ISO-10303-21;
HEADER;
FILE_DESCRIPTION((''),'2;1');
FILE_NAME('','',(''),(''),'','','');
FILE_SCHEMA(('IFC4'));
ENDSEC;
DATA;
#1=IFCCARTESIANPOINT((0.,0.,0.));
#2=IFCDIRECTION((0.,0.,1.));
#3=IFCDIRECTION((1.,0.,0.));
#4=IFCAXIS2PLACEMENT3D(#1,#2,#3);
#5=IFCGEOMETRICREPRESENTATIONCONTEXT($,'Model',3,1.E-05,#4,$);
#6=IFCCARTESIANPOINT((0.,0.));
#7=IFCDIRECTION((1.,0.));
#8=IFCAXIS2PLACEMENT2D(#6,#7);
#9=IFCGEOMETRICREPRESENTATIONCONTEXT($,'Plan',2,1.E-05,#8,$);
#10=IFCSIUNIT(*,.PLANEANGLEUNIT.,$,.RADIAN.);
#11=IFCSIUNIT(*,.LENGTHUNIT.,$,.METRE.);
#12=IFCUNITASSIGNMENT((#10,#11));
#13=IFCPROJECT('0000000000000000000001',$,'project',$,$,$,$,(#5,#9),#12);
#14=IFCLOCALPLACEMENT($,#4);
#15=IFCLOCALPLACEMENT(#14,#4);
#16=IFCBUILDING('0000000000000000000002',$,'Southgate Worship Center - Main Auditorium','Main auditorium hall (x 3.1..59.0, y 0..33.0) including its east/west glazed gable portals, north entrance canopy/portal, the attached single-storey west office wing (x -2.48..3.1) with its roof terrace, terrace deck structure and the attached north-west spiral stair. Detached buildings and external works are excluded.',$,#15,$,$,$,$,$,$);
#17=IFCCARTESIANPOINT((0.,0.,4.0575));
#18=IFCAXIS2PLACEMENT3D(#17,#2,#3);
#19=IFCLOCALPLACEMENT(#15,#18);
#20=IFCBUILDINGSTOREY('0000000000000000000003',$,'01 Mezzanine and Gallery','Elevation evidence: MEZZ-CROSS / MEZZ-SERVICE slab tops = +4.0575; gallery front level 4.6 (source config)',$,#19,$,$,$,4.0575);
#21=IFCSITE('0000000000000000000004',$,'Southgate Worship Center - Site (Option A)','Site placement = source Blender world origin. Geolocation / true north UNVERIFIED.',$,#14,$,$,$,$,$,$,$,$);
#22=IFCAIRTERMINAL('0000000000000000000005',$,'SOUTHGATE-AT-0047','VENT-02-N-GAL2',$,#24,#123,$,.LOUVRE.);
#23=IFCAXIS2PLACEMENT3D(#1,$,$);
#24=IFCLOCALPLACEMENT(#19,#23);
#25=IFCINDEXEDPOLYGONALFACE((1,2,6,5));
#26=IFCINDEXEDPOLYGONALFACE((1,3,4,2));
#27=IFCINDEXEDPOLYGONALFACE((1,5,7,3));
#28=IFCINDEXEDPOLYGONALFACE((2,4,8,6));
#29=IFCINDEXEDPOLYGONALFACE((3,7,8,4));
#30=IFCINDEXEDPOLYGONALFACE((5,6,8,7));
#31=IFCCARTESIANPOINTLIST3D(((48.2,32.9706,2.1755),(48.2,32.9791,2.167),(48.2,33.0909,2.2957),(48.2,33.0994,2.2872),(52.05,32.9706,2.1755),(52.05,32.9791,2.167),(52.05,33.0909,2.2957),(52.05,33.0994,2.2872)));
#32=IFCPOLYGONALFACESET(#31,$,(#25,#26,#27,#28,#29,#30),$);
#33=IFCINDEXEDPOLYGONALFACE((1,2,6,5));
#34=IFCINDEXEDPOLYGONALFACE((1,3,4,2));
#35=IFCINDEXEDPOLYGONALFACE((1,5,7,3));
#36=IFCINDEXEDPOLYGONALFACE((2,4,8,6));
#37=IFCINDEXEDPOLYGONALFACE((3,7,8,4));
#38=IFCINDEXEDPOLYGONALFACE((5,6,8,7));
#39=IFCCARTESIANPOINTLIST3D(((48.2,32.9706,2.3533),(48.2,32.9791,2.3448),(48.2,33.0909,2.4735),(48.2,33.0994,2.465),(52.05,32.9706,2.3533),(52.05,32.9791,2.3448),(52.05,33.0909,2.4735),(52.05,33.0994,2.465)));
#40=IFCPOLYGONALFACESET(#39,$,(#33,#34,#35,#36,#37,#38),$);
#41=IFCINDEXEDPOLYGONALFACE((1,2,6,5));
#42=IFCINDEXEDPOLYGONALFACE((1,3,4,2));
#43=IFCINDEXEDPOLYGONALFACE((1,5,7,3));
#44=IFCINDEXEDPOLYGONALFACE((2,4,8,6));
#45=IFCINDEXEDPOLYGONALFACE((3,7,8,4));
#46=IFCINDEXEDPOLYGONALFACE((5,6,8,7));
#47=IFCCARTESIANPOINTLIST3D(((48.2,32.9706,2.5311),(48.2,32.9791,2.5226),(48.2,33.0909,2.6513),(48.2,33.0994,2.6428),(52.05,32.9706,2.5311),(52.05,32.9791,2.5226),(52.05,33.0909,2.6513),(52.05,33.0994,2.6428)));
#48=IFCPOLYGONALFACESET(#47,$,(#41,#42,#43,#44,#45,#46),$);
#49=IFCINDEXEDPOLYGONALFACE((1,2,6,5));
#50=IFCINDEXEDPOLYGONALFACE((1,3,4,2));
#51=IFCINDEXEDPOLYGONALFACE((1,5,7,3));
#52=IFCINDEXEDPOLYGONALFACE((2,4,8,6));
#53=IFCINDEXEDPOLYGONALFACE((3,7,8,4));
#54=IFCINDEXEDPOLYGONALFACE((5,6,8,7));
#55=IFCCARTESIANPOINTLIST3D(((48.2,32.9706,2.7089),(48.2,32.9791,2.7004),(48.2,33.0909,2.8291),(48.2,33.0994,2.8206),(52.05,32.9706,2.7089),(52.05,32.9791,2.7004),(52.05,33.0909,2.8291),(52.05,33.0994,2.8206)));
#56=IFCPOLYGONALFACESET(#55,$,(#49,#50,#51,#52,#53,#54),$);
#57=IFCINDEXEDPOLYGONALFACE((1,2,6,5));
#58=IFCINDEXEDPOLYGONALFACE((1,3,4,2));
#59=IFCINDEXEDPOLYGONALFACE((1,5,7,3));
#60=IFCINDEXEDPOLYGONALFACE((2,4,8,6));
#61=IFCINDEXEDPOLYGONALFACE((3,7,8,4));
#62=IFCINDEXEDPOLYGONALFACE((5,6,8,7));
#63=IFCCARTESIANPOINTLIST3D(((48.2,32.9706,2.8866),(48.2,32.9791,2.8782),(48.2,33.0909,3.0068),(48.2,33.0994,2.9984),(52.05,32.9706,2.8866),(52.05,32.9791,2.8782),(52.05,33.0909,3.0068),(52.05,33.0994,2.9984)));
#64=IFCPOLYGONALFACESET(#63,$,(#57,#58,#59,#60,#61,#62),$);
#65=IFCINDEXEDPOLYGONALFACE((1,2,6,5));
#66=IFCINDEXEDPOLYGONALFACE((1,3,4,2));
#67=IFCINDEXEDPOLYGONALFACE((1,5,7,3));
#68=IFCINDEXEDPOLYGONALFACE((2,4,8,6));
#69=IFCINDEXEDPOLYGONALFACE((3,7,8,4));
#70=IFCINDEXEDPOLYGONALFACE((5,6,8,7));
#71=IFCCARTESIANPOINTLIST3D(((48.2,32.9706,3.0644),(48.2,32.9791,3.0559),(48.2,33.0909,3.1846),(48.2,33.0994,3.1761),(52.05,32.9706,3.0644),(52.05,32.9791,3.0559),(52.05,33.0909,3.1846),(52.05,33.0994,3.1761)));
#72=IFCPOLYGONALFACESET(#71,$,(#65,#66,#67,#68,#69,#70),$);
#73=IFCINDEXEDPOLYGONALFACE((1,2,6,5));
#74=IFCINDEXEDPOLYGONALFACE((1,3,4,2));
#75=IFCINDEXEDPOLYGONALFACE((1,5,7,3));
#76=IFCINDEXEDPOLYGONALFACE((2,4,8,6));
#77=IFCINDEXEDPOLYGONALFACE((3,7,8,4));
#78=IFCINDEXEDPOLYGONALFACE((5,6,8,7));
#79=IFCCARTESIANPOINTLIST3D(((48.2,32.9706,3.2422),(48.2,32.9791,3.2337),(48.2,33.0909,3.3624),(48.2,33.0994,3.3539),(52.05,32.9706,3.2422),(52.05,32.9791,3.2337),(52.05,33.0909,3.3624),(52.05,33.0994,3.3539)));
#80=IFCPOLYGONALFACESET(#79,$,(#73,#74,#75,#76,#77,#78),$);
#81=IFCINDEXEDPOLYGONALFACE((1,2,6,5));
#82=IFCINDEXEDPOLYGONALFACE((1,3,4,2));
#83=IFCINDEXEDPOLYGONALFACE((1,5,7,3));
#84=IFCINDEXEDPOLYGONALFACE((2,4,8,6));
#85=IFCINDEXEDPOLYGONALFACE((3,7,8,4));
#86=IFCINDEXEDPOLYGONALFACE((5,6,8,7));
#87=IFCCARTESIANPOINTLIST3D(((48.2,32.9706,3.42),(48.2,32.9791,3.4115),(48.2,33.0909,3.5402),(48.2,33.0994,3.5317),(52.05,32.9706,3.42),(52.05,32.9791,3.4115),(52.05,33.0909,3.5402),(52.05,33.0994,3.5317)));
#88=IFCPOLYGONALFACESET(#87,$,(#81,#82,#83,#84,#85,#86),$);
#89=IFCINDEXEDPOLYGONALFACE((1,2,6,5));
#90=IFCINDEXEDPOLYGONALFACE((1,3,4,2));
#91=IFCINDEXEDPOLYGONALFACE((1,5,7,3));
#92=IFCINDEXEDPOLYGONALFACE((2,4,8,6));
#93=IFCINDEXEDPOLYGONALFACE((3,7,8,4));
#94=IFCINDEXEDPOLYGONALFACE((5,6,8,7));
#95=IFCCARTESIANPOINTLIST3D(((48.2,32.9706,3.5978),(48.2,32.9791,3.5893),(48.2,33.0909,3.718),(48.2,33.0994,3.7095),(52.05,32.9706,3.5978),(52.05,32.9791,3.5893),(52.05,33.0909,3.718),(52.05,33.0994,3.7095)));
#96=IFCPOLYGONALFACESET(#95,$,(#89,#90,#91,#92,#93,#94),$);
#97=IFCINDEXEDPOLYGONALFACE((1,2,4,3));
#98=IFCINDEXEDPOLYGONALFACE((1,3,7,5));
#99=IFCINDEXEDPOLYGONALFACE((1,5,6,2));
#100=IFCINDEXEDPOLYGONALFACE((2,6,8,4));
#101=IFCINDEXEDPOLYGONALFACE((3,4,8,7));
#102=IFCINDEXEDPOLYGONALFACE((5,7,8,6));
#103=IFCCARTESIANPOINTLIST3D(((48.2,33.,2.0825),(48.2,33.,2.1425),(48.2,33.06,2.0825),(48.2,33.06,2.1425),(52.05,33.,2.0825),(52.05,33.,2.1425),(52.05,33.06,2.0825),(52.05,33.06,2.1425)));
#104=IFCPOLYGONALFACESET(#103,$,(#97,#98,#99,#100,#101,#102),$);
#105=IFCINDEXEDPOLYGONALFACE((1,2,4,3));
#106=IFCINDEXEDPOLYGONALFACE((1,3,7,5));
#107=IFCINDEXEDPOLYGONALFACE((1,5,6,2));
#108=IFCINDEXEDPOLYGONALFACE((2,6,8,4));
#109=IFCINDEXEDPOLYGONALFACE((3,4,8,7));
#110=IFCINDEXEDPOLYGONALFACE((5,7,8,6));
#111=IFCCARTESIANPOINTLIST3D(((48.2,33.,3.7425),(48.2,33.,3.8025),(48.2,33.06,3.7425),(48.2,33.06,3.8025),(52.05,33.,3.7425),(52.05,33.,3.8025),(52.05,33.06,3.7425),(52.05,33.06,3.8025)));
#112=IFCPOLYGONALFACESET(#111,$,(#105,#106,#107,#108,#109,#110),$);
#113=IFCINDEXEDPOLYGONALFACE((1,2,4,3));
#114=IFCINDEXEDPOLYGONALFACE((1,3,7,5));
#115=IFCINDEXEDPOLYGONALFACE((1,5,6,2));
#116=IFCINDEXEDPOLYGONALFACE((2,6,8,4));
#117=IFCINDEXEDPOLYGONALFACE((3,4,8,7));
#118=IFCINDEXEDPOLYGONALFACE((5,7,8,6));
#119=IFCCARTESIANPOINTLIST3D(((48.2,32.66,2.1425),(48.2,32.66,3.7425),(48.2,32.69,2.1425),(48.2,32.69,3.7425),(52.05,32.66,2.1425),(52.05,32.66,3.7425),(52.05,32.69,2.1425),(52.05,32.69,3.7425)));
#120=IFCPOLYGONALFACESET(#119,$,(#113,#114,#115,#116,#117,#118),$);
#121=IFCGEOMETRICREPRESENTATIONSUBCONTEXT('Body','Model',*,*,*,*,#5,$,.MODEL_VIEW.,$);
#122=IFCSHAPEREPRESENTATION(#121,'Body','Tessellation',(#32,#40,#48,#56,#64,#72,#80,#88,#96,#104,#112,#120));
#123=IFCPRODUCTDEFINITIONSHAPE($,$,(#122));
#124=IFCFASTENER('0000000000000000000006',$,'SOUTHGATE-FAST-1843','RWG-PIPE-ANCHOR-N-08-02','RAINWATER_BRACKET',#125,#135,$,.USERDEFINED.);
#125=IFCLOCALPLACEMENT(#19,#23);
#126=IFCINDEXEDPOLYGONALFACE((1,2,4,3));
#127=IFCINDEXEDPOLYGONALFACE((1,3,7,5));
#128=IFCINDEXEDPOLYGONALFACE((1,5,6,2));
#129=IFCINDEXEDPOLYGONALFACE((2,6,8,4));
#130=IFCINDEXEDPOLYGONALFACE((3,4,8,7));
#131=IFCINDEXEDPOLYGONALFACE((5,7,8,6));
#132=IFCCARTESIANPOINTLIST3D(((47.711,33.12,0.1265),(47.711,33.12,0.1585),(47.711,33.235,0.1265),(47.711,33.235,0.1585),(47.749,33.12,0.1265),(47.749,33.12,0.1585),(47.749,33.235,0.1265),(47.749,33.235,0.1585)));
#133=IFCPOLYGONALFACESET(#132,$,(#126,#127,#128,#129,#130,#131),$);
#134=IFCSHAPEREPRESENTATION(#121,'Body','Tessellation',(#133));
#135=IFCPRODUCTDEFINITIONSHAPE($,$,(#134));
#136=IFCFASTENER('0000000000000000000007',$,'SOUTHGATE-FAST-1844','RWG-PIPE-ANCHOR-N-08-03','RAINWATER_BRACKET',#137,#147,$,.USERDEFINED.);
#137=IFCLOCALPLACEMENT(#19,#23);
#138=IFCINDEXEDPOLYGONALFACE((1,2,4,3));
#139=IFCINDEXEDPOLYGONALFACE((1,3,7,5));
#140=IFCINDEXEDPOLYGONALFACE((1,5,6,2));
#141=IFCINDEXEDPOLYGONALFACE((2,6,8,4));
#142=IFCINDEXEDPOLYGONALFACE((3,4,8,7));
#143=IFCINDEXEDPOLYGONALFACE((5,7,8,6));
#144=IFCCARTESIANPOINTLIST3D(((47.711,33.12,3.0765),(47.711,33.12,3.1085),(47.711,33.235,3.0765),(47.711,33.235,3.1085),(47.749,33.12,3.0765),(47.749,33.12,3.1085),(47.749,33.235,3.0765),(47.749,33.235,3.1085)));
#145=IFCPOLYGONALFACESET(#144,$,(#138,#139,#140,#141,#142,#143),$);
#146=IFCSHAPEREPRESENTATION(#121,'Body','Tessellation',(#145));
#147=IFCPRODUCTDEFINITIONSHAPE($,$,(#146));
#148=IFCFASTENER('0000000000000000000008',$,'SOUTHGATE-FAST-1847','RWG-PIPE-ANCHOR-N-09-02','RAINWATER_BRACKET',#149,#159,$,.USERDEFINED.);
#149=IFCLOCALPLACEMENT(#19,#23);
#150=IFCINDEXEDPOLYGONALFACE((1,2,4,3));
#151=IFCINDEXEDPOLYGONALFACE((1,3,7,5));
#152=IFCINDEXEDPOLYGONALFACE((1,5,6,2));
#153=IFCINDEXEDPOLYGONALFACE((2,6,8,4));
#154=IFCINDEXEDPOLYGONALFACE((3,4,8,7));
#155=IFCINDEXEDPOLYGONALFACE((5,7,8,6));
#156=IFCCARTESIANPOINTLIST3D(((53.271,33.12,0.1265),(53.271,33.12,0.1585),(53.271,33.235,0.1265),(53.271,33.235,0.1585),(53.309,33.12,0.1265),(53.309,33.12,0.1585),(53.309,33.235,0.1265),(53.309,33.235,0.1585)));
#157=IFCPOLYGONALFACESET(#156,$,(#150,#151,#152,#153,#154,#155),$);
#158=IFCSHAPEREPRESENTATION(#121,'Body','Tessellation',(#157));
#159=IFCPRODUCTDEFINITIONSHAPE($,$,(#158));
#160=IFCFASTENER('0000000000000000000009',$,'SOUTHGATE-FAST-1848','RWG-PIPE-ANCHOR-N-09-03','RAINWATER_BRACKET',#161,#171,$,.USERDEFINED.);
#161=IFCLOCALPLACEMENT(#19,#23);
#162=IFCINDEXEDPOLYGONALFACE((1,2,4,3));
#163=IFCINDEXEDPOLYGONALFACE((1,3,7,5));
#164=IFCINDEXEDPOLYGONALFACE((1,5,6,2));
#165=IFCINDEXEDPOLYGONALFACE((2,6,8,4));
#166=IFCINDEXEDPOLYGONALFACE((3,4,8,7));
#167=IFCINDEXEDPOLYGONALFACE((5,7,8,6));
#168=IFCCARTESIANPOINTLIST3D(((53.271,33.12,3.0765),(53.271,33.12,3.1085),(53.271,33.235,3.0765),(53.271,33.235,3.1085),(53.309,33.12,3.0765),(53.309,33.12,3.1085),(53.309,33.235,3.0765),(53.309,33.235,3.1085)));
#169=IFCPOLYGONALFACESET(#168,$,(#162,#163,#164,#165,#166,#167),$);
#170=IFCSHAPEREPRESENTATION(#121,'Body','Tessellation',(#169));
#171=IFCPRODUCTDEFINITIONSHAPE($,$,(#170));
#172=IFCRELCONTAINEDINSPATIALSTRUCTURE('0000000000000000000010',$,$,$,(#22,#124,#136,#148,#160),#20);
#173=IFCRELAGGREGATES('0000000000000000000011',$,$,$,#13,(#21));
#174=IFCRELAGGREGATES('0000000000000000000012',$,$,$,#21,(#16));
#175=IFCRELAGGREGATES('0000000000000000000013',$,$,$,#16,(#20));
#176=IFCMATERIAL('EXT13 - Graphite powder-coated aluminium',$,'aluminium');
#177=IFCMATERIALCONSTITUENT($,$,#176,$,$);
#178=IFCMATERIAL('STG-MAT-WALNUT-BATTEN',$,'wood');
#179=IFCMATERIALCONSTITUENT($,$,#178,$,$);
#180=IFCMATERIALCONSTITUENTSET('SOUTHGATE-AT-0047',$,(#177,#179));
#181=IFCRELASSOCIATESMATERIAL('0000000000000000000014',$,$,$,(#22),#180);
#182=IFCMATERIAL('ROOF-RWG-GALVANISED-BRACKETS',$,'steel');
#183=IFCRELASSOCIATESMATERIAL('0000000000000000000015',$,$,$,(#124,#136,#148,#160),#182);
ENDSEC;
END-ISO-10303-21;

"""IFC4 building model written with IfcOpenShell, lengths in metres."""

from ifc_helpers import new_model, si_unit, frame, origin_with_axes, origin_2d, origin_2d_with_axis, place, context, subcontext, project, spatial, rectangle, extrude, material, constituent, constituent_set, element, save


model = new_model("IFC4")

# Units and contexts
model_context = context("Model", 3, precision=1e-05, world=origin_with_axes())
plan_context = context("Plan", 2, precision=1e-05, world=origin_2d_with_axis())
body_context = subcontext(model_context, "Body", "Model", "MODEL_VIEW")
ifc_project = project(units=[si_unit("PLANEANGLEUNIT", "RADIAN"), si_unit("LENGTHUNIT", "METRE")], contexts=[model_context, plan_context])

# Site, building, storey
site_placement = place(None, origin_with_axes())
site = spatial("IfcSite", under=ifc_project, at=site_placement, Name="Southgate Worship Center - Site (Option A)", Description="Site placement = source Blender world origin. Geolocation / true north UNVERIFIED.")
building_placement = place(site_placement, origin_with_axes())
building = spatial("IfcBuilding", under=site, at=building_placement, Name="Southgate Worship Center - Main Auditorium", Description="Main auditorium hall (x 3.1..59.0, y 0..33.0) including its east/west glazed gable portals, north entrance canopy/portal, the attached single-storey west office wing (x -2.48..3.1) with its roof terrace, terrace deck structure and the attached north-west spiral stair. Detached buildings and external works are excluded.")
storey_placement = place(building_placement, frame((0.0, 0.0, 4.0575), z_axis=(0.0, 0.0, 1.0), x_axis=(1.0, 0.0, 0.0)))
storey = spatial("IfcBuildingStorey", under=building, at=storey_placement, Name="01 Mezzanine and Gallery", Description="Elevation evidence: MEZZ-CROSS / MEZZ-SERVICE slab tops = +4.0575; gallery front level 4.6 (source config)", Elevation=4.0575)

# Air terminal
ifc_material_1 = material(Name="EXT13 - Graphite powder-coated aluminium", Category="aluminium")
ifc_constituent_1 = constituent(ifc_material_1)
ifc_material_2 = material(Name="STG-MAT-WALNUT-BATTEN", Category="wood")
ifc_constituent_2 = constituent(ifc_material_2)
ifc_constituent_set = constituent_set(constituents=[ifc_constituent_1, ifc_constituent_2], Name="SOUTHGATE-AT-0047")
air_terminal_placement = place(storey_placement, frame((48.2, 32.66, 2.0825), z_axis=(0.0, 0.0, 1.0), x_axis=(1.0, 0.0, 0.0)))
element("IfcAirTerminal", 1, at=air_terminal_placement, inside=storey, material=ifc_constituent_set, Name="SOUTHGATE-AT-0047", Description="VENT-02-N-GAL2", PredefinedType="LOUVRE", context=body_context, shape_type="SweptSolid", body=[
    extrude(rectangle(XDim=0.012, YDim=0.17, at=origin_2d()), frame((0.0, 0.375, 0.1489), z_axis=(1.0, 0.0, 0.0), x_axis=(0.0, 0.707047, -0.707166)), (0.0, 0.0, 1.0), 3.85),
    extrude(rectangle(XDim=0.012, YDim=0.17, at=origin_2d()), frame((0.0, 0.375, 0.3267), z_axis=(1.0, 0.0, 0.0), x_axis=(0.0, 0.707047, -0.707166)), (0.0, 0.0, 1.0), 3.85),
    extrude(rectangle(XDim=0.012, YDim=0.17, at=origin_2d()), frame((0.0, 0.375, 0.5044), z_axis=(1.0, 0.0, 0.0), x_axis=(0.0, 0.707047, -0.707166)), (0.0, 0.0, 1.0), 3.85),
    extrude(rectangle(XDim=0.012, YDim=0.17, at=origin_2d()), frame((0.0, 0.375, 0.6822), z_axis=(1.0, 0.0, 0.0), x_axis=(0.0, 0.707047, -0.707166)), (0.0, 0.0, 1.0), 3.85),
    extrude(rectangle(XDim=0.012, YDim=0.17, at=origin_2d()), frame((0.0, 0.375, 0.86), z_axis=(1.0, 0.0, 0.0), x_axis=(0.0, 0.707047, -0.707166)), (0.0, 0.0, 1.0), 3.85),
    extrude(rectangle(XDim=0.012, YDim=0.17, at=origin_2d()), frame((0.0, 0.375, 1.0378), z_axis=(1.0, 0.0, 0.0), x_axis=(0.0, 0.707047, -0.707166)), (0.0, 0.0, 1.0), 3.85),
    extrude(rectangle(XDim=0.012, YDim=0.17, at=origin_2d()), frame((0.0, 0.375, 1.2156), z_axis=(1.0, 0.0, 0.0), x_axis=(0.0, 0.707047, -0.707166)), (0.0, 0.0, 1.0), 3.85),
    extrude(rectangle(XDim=0.012, YDim=0.17, at=origin_2d()), frame((0.0, 0.375, 1.3933), z_axis=(1.0, 0.0, 0.0), x_axis=(0.0, 0.707047, -0.707166)), (0.0, 0.0, 1.0), 3.85),
    extrude(rectangle(XDim=0.012, YDim=0.17, at=origin_2d()), frame((0.0, 0.375, 1.5711), z_axis=(1.0, 0.0, 0.0), x_axis=(0.0, 0.707047, -0.707166)), (0.0, 0.0, 1.0), 3.85),
    extrude(rectangle(XDim=0.06, YDim=3.85, at=origin_2d()), frame((1.925, 0.37, 0.0), z_axis=(0.0, 0.0, 1.0), x_axis=(0.0, -1.0, 0.0)), (0.0, 0.0, 1.0), 0.06),
    extrude(rectangle(XDim=0.06, YDim=3.85, at=origin_2d()), frame((1.925, 0.37, 1.66), z_axis=(0.0, 0.0, 1.0), x_axis=(0.0, -1.0, 0.0)), (0.0, 0.0, 1.0), 0.06),
    extrude(rectangle(XDim=0.03, YDim=3.85, at=origin_2d()), frame((1.925, 0.015, 0.06), z_axis=(0.0, 0.0, 1.0), x_axis=(0.0, -1.0, 0.0)), (0.0, 0.0, 1.0), 1.6),
])

# Fasteners
ifc_material_3 = material(Name="ROOF-RWG-GALVANISED-BRACKETS", Category="steel")
fastener_1_placement = place(storey_placement, frame((47.711, 33.12, 0.1265), z_axis=(0.0, 0.0, 1.0), x_axis=(1.0, 0.0, 0.0)))
element("IfcFastener", 2, at=fastener_1_placement, inside=storey, material=ifc_material_3, Name="SOUTHGATE-FAST-1843", Description="RWG-PIPE-ANCHOR-N-08-02", ObjectType="RAINWATER_BRACKET", PredefinedType="USERDEFINED", context=body_context, shape_type="SweptSolid", body=[
    extrude(rectangle(XDim=0.038, YDim=0.115, at=origin_2d()), frame((0.019, 0.0575, 0.0), z_axis=(0.0, 0.0, 1.0), x_axis=(1.0, 0.0, 0.0)), (0.0, 0.0, 1.0), 0.032),
])
fastener_2_placement = place(storey_placement, frame((47.711, 33.12, 3.0765), z_axis=(0.0, 0.0, 1.0), x_axis=(1.0, 0.0, 0.0)))
element("IfcFastener", 3, at=fastener_2_placement, inside=storey, material=ifc_material_3, Name="SOUTHGATE-FAST-1844", Description="RWG-PIPE-ANCHOR-N-08-03", ObjectType="RAINWATER_BRACKET", PredefinedType="USERDEFINED", context=body_context, shape_type="SweptSolid", body=[
    extrude(rectangle(XDim=0.038, YDim=0.115, at=origin_2d()), frame((0.019, 0.0575, 0.0), z_axis=(0.0, 0.0, 1.0), x_axis=(1.0, 0.0, 0.0)), (0.0, 0.0, 1.0), 0.032),
])
fastener_3_placement = place(storey_placement, frame((53.271, 33.12, 0.1265), z_axis=(0.0, 0.0, 1.0), x_axis=(1.0, 0.0, 0.0)))
element("IfcFastener", 4, at=fastener_3_placement, inside=storey, material=ifc_material_3, Name="SOUTHGATE-FAST-1847", Description="RWG-PIPE-ANCHOR-N-09-02", ObjectType="RAINWATER_BRACKET", PredefinedType="USERDEFINED", context=body_context, shape_type="SweptSolid", body=[
    extrude(rectangle(XDim=0.038, YDim=0.115, at=origin_2d()), frame((0.019, 0.0575, 0.0), z_axis=(0.0, 0.0, 1.0), x_axis=(1.0, 0.0, 0.0)), (0.0, 0.0, 1.0), 0.032),
])
fastener_4_placement = place(storey_placement, frame((53.271, 33.12, 3.0765), z_axis=(0.0, 0.0, 1.0), x_axis=(1.0, 0.0, 0.0)))
element("IfcFastener", 5, at=fastener_4_placement, inside=storey, material=ifc_material_3, Name="SOUTHGATE-FAST-1848", Description="RWG-PIPE-ANCHOR-N-09-03", ObjectType="RAINWATER_BRACKET", PredefinedType="USERDEFINED", context=body_context, shape_type="SweptSolid", body=[
    extrude(rectangle(XDim=0.038, YDim=0.115, at=origin_2d()), frame((0.019, 0.0575, 0.0), z_axis=(0.0, 0.0, 1.0), x_axis=(1.0, 0.0, 0.0)), (0.0, 0.0, 1.0), 0.032),
])

save(model, "model.ifc")
